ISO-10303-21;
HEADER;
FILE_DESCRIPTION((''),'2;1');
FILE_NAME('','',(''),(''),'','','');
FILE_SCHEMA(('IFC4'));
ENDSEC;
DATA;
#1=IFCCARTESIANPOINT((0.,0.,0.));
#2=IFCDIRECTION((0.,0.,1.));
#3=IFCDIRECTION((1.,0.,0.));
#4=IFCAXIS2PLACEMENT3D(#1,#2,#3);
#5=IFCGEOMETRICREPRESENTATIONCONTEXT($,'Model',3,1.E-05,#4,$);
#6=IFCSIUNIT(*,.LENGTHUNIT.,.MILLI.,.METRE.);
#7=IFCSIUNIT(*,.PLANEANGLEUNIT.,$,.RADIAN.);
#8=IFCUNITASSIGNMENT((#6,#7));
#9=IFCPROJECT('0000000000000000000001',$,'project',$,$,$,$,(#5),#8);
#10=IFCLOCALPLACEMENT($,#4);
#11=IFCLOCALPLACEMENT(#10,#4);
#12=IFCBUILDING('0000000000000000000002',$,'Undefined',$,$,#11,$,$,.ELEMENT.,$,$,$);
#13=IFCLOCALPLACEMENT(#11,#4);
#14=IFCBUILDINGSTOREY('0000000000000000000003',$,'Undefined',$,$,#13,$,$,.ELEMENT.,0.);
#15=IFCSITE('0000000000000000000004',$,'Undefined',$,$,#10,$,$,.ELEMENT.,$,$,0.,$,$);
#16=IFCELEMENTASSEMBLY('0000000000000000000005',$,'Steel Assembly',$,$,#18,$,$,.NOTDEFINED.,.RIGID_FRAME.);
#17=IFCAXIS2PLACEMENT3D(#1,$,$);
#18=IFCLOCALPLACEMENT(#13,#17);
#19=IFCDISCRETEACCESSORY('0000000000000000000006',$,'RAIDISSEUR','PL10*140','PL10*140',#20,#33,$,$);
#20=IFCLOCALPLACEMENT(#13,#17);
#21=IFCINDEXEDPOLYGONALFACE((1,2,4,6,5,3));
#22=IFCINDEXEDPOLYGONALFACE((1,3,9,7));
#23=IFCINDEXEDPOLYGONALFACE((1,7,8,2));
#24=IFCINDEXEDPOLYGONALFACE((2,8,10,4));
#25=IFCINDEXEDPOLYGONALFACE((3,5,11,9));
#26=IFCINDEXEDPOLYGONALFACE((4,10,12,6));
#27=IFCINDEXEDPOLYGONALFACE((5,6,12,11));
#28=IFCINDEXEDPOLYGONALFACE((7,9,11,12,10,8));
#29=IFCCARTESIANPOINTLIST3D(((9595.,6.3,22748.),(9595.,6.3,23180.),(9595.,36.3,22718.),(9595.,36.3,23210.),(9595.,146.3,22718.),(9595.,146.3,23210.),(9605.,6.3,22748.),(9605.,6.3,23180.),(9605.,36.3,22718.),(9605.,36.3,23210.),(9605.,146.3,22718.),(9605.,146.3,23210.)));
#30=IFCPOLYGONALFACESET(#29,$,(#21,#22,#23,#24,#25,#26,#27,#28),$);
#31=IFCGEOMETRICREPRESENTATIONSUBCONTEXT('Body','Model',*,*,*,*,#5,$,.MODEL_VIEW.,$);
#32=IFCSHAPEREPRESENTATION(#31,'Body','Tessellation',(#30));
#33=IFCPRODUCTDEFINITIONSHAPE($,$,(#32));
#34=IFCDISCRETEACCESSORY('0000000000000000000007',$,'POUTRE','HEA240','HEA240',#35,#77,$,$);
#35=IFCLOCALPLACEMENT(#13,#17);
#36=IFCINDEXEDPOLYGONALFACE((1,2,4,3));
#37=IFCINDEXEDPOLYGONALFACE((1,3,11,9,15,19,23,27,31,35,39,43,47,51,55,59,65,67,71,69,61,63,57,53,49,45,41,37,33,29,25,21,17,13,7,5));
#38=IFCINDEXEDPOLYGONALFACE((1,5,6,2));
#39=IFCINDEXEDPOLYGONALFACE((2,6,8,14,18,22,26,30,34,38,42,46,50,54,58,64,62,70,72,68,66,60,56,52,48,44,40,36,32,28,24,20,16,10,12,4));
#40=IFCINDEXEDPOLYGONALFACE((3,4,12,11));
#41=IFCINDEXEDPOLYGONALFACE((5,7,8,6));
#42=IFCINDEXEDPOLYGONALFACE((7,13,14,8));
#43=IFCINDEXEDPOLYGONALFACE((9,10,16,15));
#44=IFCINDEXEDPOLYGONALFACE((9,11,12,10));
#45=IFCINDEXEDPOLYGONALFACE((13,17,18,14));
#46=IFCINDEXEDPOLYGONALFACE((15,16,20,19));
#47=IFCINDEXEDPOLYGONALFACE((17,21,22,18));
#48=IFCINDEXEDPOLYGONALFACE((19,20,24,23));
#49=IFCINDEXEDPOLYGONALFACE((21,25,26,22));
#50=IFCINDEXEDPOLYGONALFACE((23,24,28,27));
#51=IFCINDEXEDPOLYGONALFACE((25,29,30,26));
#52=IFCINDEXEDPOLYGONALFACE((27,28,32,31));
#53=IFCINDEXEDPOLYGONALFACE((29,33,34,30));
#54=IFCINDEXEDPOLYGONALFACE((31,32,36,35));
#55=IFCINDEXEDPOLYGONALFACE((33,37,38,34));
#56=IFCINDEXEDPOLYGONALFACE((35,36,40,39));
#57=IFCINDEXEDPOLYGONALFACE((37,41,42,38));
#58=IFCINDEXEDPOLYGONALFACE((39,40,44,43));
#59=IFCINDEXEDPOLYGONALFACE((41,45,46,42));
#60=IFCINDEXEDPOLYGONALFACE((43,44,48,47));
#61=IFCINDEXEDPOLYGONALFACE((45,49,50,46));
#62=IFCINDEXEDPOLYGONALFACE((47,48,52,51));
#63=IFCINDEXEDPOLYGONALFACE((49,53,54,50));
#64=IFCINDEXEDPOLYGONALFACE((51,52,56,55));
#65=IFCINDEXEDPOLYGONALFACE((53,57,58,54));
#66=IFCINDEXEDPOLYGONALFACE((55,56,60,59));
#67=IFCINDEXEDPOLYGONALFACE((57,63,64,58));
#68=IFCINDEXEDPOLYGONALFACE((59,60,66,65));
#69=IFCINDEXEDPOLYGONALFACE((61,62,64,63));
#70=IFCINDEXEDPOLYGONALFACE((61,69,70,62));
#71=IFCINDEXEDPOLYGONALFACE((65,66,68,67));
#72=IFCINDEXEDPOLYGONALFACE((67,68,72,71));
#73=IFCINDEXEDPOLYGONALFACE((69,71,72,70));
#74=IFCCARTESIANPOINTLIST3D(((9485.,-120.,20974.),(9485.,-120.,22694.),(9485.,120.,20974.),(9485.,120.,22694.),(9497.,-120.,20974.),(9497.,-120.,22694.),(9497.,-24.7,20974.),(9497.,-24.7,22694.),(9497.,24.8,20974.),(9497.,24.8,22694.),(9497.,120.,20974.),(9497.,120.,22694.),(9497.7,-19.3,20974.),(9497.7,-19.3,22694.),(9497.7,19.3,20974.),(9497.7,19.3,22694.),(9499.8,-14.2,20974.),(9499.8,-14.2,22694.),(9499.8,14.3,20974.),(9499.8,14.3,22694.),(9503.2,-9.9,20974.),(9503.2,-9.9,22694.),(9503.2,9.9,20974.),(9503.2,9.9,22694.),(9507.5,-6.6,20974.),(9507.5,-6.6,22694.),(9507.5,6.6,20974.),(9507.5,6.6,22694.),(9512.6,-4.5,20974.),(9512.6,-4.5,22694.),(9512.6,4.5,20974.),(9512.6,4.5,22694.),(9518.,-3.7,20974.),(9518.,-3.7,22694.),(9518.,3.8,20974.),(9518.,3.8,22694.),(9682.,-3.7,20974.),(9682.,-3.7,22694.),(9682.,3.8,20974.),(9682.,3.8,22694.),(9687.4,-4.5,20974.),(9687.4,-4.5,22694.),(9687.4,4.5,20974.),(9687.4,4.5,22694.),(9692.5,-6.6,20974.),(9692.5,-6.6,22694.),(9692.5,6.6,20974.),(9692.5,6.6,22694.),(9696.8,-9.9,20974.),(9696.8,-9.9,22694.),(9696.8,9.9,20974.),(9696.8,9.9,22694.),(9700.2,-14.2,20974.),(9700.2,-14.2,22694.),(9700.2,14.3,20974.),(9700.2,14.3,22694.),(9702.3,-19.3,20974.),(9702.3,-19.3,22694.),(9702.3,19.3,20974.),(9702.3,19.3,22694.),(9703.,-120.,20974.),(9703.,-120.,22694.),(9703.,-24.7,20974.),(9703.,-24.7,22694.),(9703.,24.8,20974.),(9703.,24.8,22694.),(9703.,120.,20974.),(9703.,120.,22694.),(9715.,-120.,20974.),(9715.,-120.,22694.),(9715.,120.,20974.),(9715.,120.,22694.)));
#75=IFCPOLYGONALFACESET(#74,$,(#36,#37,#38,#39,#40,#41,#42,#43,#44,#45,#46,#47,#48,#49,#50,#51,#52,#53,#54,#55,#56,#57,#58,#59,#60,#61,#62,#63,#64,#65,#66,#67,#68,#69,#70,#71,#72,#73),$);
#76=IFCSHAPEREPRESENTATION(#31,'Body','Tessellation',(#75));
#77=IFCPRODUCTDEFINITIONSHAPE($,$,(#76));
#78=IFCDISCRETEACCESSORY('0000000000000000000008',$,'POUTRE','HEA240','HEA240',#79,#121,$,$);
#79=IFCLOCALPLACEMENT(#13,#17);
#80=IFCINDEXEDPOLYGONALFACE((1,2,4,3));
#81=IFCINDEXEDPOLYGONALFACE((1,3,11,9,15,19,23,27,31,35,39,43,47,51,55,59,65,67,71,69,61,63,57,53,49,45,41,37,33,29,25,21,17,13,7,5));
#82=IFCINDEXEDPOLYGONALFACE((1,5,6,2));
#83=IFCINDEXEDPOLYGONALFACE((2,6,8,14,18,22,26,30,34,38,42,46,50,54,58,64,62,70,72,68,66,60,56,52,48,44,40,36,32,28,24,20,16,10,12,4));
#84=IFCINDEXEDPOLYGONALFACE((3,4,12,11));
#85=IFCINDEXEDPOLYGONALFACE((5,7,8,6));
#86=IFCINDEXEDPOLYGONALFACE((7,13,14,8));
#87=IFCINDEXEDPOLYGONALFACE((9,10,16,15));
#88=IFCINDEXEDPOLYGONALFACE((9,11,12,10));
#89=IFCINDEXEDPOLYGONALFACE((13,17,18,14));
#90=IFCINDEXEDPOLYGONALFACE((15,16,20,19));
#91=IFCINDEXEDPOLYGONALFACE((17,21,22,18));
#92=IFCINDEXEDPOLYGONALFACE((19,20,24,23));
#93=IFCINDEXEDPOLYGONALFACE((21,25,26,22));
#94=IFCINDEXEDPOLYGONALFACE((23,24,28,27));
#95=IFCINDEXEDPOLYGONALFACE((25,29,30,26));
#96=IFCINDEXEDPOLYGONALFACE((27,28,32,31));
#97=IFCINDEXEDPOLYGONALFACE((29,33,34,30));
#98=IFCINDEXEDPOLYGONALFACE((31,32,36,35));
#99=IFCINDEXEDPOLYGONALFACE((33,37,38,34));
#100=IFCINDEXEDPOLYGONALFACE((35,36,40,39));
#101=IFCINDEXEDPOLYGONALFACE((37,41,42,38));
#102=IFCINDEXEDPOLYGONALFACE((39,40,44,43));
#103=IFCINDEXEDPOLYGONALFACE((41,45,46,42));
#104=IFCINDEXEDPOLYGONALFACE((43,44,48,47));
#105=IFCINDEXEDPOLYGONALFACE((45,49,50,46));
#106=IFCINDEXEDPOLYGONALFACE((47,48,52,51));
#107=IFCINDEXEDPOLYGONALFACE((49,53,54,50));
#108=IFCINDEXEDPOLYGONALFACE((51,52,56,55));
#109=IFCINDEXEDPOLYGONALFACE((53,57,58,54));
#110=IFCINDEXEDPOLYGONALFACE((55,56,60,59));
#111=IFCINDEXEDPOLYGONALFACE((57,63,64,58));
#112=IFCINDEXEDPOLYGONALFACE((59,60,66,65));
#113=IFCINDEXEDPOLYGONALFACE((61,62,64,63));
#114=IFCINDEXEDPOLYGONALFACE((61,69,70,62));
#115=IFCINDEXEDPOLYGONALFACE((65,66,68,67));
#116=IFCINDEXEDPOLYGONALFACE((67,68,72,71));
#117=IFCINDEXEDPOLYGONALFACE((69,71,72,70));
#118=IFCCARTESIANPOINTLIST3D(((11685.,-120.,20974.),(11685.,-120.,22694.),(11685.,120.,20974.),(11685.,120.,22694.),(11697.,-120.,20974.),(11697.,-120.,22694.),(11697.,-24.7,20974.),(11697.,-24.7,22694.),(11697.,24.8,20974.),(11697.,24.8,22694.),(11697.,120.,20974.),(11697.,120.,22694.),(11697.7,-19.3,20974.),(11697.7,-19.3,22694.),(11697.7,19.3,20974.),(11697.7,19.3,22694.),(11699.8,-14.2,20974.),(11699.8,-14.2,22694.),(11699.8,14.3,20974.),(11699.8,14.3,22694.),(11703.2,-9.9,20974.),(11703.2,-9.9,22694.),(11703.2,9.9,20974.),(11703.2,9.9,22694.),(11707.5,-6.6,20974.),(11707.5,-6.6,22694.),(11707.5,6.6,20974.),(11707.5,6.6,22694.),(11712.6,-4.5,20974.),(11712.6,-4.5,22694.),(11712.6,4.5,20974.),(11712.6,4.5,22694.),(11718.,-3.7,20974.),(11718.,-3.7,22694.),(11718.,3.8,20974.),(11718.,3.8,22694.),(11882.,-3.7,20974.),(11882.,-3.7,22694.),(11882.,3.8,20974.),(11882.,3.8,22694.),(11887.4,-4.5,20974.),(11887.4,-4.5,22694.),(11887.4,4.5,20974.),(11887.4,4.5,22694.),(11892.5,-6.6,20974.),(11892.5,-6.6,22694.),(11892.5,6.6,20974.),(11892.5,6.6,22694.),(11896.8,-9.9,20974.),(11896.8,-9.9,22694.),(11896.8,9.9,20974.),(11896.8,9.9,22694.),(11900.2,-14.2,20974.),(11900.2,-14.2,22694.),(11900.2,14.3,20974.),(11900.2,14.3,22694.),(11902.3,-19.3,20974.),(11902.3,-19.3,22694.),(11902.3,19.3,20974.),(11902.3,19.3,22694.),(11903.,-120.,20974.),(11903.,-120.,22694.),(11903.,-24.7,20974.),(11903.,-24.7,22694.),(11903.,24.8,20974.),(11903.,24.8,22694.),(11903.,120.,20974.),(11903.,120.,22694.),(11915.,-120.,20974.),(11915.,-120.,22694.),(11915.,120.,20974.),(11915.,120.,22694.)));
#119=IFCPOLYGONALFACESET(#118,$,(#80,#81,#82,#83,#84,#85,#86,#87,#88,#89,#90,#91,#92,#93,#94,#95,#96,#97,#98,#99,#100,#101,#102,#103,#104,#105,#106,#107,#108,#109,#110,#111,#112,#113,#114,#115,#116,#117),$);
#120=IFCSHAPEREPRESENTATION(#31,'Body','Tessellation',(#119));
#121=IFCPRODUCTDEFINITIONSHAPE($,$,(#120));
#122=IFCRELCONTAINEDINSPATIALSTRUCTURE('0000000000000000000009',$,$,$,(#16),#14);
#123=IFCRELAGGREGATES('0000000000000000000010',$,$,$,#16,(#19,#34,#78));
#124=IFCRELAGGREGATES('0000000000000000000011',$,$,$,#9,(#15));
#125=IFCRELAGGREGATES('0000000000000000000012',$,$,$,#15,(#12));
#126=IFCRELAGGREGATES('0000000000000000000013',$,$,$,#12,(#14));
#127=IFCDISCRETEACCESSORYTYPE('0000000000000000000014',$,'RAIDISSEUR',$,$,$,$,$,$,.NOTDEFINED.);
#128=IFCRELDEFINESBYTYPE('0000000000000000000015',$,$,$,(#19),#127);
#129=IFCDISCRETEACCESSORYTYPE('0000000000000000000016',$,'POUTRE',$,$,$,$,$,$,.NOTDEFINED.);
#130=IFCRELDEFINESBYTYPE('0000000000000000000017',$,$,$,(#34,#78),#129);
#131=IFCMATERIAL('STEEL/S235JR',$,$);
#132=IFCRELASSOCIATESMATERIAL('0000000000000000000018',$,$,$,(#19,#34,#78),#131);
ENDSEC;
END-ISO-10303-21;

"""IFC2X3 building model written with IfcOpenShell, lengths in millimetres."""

from ifc_helpers import new_model, si_unit, frame, origin_with_axes, origin_2d_with_axis, place, context, subcontext, project, spatial, polyline, i_section, outline, extrude, material, type_object, element, aggregate, save


model = new_model("IFC2X3")

# Units and contexts
model_context = context("Model", 3, precision=1e-05, world=origin_with_axes())
body_context = subcontext(model_context, "Body", "Model", "MODEL_VIEW")
ifc_project = project(units=[si_unit("LENGTHUNIT", "METRE", prefix="MILLI"), si_unit("PLANEANGLEUNIT", "RADIAN")], contexts=[model_context])

# Site, building, storey
site_placement = place(None, origin_with_axes())
site = spatial("IfcSite", under=ifc_project, at=site_placement, Name="Undefined", CompositionType="ELEMENT", RefElevation=0.0)
building_placement = place(site_placement, origin_with_axes())
building = spatial("IfcBuilding", under=site, at=building_placement, Name="Undefined", CompositionType="ELEMENT")
storey_placement = place(building_placement, origin_with_axes())
storey = spatial("IfcBuildingStorey", under=building, at=storey_placement, Name="Undefined", CompositionType="ELEMENT", Elevation=0.0)

# Shared definitions
ifc_material_1 = material(Name="STEEL/S235JR")

# Element assembly
assembly_1_placement = place(storey_placement, origin_with_axes())
assembly_1 = element("IfcElementAssembly", 1, at=assembly_1_placement, inside=storey, Name="Steel Assembly", AssemblyPlace="NOTDEFINED", PredefinedType="RIGID_FRAME")

# Discrete accessory
discrete_accessory_type_1 = type_object("IfcDiscreteAccessoryType", Name="RAIDISSEUR")
discrete_accessory_1_placement = place(assembly_1_placement, frame((9600.0, 6.3, 22718.0), z_axis=(1.0, 0.000008, 0.0), x_axis=(-0.000008, 1.0, 0.0)))
discrete_accessory_1 = element("IfcDiscreteAccessory", 2, at=discrete_accessory_1_placement, type_object=discrete_accessory_type_1, material=ifc_material_1, Name="RAIDISSEUR", Description="PL10*140", ObjectType="PL10*140", context=body_context, shape_type="SweptSolid", body=[
    extrude(outline(polyline([(0.0, 30.0), (30.0, 0.0), (140.0, 0.0), (140.0, 492.0), (30.0, 492.0), (0.0, 462.0), (0.0, 30.0)])), frame((0.0, 0.0, -5.0), z_axis=(0.0, 0.0, 1.0), x_axis=(1.0, 0.0, 0.0)), (0.0, 0.0, 1.0), 10.0),
])

# Discrete accessories
discrete_accessory_type_2 = type_object("IfcDiscreteAccessoryType", Name="POUTRE")
discrete_accessory_2_placement = place(assembly_1_placement, frame((9600.0, 0.0, 20974.0), z_axis=(0.0, 0.0, 1.0), x_axis=(1.0, 0.0, 0.0)))
discrete_accessory_2 = element("IfcDiscreteAccessory", 3, at=discrete_accessory_2_placement, type_object=discrete_accessory_type_2, material=ifc_material_1, Name="POUTRE", Description="HEA240", ObjectType="HEA240", context=body_context, shape_type="SweptSolid", body=[
    extrude(i_section(OverallWidth=240.0, OverallDepth=230.0, WebThickness=7.5, FlangeThickness=12.0, FilletRadius=21.0, at=origin_2d_with_axis()), frame((0.0, 0.0, 1720.0), z_axis=(0.0, 0.0, -1.0), x_axis=(0.0, -1.0, 0.0)), (0.0, 0.0, 1.0), 1720.0),
])
discrete_accessory_3_placement = place(assembly_1_placement, frame((11800.0, 0.0, 20974.0), z_axis=(0.0, 0.0, 1.0), x_axis=(1.0, 0.0, 0.0)))
discrete_accessory_3 = element("IfcDiscreteAccessory", 4, at=discrete_accessory_3_placement, type_object=discrete_accessory_type_2, material=ifc_material_1, Name="POUTRE", Description="HEA240", ObjectType="HEA240", context=body_context, shape_type="SweptSolid", body=[
    extrude(i_section(OverallWidth=240.0, OverallDepth=230.0, WebThickness=7.5, FlangeThickness=12.0, FilletRadius=21.0, at=origin_2d_with_axis()), frame((0.0, 0.0, 1720.0), z_axis=(0.0, 0.0, -1.0), x_axis=(0.0, -1.0, 0.0)), (0.0, 0.0, 1.0), 1720.0),
])
aggregate(assembly_1, [discrete_accessory_1, discrete_accessory_2, discrete_accessory_3])

save(model, "model.ifc")
